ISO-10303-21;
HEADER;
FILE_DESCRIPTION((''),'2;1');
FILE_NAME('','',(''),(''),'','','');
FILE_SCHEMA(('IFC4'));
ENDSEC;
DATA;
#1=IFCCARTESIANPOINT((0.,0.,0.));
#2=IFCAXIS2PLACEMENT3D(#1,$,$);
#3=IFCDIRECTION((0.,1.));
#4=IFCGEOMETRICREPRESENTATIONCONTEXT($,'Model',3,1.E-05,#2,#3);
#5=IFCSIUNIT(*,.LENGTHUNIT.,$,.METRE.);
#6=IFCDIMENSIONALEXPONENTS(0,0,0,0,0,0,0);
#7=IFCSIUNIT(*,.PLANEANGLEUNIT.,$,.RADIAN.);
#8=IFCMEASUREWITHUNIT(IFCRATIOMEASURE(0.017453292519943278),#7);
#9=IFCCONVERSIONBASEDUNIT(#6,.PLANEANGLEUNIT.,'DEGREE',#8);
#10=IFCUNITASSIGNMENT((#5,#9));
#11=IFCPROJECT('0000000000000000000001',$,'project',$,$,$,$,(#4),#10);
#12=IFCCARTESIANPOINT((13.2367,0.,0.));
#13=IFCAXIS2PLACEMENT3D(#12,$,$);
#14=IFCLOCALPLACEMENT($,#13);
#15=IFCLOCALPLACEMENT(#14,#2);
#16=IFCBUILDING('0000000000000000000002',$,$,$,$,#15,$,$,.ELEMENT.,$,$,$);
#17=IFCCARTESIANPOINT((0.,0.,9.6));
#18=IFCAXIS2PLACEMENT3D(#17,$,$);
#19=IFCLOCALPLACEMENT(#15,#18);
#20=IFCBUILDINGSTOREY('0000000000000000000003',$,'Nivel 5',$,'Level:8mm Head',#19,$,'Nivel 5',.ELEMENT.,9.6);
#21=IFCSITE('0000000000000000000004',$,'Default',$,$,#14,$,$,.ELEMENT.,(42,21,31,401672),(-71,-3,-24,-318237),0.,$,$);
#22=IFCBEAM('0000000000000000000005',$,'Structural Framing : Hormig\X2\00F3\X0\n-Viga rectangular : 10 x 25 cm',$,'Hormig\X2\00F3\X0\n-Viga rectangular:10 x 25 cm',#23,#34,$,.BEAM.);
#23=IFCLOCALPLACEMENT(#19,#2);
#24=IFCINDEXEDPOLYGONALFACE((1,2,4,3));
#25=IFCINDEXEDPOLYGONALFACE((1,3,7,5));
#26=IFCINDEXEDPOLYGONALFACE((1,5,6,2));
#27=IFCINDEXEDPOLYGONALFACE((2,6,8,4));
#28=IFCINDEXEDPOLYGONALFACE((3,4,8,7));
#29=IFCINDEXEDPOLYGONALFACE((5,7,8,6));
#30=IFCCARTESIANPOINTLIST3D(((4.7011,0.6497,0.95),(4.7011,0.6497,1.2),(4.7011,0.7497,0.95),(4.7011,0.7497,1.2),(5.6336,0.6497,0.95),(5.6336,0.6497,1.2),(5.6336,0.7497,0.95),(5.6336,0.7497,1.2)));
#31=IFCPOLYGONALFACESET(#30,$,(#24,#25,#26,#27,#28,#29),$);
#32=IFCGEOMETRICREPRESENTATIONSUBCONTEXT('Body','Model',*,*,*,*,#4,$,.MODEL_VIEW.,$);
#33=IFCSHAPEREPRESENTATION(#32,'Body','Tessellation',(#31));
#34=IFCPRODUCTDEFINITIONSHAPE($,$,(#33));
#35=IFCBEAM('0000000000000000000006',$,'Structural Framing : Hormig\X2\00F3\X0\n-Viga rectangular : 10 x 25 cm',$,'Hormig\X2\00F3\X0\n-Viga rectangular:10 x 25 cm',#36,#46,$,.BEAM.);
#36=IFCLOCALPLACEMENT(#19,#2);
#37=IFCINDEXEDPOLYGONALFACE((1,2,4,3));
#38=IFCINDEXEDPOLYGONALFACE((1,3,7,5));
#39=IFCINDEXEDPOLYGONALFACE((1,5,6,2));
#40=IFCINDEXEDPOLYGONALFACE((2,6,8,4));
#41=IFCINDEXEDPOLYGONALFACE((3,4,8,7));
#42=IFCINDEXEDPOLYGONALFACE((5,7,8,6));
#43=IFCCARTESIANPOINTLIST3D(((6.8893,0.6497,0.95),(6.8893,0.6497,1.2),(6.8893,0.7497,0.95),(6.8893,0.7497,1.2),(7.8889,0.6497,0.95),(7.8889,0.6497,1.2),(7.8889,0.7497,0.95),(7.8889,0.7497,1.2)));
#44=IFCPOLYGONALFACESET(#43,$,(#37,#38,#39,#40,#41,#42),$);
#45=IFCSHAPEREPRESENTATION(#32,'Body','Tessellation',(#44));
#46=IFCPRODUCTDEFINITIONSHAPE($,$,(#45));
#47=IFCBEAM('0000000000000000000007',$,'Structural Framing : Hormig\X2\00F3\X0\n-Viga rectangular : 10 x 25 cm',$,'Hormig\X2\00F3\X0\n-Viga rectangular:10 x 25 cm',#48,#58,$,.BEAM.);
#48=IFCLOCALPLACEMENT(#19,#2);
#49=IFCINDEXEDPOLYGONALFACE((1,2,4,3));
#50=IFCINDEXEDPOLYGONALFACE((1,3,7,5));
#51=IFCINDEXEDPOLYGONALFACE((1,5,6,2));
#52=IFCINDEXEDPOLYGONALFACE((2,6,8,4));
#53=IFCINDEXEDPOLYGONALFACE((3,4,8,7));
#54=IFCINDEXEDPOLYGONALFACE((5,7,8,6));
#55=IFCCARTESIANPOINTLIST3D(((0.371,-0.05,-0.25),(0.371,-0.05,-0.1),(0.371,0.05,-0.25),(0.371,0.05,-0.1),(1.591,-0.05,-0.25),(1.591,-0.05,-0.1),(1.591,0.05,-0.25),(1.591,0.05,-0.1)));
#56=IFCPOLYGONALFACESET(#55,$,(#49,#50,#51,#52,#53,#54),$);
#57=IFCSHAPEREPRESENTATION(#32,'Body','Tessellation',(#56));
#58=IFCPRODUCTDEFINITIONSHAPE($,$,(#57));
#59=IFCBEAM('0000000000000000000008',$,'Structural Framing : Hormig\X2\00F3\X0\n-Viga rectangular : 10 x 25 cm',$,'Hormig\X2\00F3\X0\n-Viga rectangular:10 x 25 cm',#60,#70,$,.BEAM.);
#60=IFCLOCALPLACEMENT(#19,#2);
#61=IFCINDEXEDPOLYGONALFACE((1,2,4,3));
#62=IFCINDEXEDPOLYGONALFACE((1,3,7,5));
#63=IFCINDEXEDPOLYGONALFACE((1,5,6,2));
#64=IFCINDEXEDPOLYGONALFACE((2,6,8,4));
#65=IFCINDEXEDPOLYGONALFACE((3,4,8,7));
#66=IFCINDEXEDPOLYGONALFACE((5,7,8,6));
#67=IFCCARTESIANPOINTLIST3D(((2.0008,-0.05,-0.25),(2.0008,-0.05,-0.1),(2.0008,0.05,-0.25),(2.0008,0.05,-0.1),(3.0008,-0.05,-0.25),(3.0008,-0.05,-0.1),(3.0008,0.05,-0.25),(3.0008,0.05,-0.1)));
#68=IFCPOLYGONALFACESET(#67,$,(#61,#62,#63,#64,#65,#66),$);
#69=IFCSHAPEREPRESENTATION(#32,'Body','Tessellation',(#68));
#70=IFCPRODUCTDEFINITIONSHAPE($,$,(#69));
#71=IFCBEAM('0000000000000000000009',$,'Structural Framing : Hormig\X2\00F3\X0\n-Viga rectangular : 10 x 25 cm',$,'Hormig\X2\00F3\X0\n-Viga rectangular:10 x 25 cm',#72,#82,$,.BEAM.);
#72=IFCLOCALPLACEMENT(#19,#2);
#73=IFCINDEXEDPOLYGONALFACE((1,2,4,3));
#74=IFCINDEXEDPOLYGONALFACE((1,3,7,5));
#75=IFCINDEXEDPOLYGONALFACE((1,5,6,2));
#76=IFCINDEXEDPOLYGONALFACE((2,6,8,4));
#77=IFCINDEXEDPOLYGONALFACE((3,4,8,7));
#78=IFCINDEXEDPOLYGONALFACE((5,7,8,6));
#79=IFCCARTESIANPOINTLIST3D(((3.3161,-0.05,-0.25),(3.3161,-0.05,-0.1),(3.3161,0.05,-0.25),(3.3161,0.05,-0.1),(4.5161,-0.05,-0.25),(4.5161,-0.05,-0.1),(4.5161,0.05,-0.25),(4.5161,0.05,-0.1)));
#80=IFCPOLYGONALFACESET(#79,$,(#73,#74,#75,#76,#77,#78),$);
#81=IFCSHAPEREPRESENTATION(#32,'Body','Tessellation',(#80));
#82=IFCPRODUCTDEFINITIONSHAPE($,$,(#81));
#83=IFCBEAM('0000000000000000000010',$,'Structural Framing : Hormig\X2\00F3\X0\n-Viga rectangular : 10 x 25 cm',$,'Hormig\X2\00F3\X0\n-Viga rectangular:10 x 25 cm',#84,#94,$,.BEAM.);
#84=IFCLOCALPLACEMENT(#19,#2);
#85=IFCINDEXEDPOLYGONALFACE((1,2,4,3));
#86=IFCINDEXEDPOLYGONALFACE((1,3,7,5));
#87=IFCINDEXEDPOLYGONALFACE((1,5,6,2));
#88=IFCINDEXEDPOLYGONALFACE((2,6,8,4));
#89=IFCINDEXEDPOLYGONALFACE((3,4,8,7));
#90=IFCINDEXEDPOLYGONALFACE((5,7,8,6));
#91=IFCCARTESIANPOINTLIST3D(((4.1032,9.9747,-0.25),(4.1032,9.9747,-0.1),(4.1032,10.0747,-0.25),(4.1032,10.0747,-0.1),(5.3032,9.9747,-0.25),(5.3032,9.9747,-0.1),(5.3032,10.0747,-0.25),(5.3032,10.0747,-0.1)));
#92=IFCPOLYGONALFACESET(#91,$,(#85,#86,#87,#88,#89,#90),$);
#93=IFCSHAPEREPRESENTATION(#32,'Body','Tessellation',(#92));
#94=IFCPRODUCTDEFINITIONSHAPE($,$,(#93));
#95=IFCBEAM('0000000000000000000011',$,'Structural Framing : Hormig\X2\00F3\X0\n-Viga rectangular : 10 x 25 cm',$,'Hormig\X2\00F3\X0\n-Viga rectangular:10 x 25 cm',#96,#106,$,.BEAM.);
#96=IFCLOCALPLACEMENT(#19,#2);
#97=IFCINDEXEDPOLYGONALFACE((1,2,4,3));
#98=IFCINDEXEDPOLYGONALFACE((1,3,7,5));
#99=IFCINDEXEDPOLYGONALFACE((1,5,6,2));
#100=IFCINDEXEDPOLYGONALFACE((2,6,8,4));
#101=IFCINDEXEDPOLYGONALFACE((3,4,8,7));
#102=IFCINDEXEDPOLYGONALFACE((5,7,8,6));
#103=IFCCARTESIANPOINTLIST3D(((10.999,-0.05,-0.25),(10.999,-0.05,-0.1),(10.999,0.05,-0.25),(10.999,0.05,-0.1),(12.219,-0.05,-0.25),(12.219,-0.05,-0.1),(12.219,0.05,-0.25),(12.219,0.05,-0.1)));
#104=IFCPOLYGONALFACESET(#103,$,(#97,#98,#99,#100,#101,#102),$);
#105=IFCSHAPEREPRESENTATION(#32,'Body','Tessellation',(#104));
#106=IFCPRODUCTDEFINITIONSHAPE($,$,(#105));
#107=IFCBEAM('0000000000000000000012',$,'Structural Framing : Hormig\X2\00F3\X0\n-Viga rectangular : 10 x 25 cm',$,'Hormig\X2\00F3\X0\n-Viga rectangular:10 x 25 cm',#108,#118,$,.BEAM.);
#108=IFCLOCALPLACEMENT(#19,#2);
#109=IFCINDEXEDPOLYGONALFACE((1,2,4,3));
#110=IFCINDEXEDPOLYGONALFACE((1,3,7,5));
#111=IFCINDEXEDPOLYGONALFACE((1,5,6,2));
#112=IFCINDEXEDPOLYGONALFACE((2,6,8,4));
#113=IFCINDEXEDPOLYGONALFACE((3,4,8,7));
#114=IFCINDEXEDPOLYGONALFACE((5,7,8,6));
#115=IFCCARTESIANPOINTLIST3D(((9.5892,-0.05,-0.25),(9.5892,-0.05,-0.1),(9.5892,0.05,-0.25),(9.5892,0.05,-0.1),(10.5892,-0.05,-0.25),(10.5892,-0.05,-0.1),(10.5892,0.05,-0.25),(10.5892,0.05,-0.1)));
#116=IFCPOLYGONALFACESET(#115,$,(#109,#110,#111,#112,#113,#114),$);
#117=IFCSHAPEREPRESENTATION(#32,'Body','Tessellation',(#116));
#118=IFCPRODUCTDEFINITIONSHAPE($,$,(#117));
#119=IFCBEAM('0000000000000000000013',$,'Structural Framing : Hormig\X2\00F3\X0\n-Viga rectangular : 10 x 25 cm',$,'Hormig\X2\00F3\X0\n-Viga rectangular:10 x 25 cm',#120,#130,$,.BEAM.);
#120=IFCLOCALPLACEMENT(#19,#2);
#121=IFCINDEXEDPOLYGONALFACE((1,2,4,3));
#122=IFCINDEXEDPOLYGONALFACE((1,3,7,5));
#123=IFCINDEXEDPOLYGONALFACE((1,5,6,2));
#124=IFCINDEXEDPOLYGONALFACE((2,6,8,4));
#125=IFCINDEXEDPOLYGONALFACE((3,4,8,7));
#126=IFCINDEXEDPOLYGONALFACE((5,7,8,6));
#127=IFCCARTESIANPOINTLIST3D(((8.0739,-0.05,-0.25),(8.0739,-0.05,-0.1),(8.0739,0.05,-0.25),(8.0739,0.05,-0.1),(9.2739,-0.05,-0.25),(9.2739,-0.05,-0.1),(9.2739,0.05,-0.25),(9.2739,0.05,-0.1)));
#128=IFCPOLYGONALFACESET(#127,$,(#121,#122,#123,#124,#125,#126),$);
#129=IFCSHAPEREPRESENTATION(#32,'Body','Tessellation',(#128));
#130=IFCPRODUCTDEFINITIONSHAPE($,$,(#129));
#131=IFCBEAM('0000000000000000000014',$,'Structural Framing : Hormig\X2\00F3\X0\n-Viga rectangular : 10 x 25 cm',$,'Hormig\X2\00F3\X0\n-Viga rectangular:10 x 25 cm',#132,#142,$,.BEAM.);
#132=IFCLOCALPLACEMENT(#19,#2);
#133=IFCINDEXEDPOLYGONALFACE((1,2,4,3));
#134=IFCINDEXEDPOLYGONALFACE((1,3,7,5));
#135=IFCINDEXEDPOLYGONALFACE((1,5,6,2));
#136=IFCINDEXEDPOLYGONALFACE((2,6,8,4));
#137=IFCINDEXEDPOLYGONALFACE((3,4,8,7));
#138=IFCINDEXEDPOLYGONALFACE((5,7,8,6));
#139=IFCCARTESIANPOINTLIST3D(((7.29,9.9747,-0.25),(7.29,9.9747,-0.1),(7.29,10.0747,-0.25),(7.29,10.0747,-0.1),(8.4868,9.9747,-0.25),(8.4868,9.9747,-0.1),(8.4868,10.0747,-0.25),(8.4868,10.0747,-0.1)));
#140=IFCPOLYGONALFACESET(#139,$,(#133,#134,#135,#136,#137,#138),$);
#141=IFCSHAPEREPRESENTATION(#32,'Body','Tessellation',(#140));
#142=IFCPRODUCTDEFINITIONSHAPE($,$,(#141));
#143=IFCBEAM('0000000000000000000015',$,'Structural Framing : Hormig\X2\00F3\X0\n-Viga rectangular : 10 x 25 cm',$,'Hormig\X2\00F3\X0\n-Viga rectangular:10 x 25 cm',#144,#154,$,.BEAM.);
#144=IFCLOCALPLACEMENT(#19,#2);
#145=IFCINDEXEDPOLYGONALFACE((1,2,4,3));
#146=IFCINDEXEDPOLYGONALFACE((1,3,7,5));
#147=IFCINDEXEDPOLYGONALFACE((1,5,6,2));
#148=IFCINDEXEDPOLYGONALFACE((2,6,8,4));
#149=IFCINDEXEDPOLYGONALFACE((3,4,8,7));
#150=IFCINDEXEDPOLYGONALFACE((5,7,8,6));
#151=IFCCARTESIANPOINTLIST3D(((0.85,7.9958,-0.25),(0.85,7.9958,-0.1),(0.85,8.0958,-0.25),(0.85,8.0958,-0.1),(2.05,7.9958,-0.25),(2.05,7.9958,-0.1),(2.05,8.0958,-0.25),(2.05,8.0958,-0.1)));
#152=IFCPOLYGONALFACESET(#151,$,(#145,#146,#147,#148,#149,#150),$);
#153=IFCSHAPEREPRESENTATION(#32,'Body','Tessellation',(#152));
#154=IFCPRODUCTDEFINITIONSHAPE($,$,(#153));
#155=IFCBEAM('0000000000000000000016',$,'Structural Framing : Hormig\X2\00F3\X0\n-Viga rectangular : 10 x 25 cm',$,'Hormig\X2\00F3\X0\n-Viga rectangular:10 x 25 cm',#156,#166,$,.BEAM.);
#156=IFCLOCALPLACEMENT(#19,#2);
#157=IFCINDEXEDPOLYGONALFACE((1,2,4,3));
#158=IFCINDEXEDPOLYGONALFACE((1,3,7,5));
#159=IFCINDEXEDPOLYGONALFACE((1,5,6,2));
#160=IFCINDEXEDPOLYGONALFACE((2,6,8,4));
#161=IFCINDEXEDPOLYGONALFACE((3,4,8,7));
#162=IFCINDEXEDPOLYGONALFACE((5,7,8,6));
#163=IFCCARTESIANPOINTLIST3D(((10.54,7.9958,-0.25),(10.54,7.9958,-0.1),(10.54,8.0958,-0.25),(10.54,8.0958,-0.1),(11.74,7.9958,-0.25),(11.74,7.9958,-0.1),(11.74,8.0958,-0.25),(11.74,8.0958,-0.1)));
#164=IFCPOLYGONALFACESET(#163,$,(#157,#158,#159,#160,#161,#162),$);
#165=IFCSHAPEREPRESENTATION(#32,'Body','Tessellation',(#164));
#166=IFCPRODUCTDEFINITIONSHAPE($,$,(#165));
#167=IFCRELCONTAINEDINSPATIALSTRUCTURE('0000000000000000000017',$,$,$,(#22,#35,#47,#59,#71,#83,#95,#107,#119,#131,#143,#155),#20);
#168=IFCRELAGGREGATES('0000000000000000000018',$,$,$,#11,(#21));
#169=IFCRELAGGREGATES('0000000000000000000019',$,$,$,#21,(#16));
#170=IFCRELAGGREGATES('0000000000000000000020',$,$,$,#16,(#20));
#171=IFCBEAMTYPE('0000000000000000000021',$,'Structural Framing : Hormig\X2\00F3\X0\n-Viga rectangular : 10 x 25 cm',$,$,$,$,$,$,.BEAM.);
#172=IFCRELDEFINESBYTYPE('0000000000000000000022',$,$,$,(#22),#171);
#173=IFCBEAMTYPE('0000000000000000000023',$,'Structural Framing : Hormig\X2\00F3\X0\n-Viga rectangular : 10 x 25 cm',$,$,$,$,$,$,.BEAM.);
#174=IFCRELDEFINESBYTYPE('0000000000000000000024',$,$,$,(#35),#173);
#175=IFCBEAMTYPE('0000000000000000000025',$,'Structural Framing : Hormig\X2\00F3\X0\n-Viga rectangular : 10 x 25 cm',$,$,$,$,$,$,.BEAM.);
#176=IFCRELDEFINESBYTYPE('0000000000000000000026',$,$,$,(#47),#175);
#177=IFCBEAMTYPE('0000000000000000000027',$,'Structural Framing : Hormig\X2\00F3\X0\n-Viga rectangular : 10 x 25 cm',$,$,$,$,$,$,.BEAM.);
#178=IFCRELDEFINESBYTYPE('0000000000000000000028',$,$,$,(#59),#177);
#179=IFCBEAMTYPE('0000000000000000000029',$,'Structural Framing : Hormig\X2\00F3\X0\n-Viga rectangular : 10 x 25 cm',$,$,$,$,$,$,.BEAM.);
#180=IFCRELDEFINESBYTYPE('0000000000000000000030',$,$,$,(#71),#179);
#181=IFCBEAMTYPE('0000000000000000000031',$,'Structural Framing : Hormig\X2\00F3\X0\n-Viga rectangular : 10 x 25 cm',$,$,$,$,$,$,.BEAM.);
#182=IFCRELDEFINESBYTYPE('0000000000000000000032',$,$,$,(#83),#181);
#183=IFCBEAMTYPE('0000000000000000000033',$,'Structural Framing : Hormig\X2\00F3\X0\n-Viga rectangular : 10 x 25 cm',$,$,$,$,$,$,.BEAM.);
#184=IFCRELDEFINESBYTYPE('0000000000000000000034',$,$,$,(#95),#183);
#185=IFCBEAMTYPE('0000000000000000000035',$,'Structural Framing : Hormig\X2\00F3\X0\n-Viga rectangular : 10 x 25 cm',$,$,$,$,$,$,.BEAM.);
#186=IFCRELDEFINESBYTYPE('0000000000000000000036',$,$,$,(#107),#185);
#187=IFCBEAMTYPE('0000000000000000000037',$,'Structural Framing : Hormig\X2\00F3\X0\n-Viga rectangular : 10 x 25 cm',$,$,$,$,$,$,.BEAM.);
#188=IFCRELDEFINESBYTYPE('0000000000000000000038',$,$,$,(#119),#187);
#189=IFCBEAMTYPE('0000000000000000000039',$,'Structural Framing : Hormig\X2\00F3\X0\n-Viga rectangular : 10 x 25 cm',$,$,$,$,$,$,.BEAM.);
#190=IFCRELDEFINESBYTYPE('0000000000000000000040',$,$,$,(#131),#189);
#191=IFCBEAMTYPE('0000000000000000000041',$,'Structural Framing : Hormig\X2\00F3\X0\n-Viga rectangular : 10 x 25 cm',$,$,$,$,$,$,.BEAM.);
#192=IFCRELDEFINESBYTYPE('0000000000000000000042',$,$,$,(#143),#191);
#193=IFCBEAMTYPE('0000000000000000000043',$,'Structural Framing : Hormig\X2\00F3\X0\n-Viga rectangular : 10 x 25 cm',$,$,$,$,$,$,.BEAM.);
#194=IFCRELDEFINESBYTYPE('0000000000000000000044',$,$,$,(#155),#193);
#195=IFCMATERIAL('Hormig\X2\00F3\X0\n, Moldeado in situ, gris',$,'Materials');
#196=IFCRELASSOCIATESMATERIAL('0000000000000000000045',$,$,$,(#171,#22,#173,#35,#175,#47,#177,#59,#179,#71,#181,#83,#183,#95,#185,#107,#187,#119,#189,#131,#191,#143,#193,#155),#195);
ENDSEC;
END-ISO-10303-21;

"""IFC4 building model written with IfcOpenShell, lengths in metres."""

from ifc_helpers import new_model, entity, si_unit, converted_unit, direction, frame, origin, place, context, subcontext, project, spatial, indexed_curve, outline, extrude, source, transform, mapped, material, type_object, type_shapes, element, save


model = new_model("IFC4")

# Units and contexts
model_context = context("Model", 3, precision=1e-05, world=origin(), true_north=direction((0.0, 1.0)))
body_context = subcontext(model_context, "Body", "Model", "MODEL_VIEW")
ifc_project = project(units=[si_unit("LENGTHUNIT", "METRE"), converted_unit("PLANEANGLEUNIT", "DEGREE", entity("IfcRatioMeasure", 0.017453292519943278), si_unit("PLANEANGLEUNIT", "RADIAN"), dimensions=[0, 0, 0, 0, 0, 0, 0])], contexts=[model_context])

# Site, building, storey
site_placement = place(None, frame((13.2367, 0.0, 0.0)))
site = spatial("IfcSite", under=ifc_project, at=site_placement, Name="Default", CompositionType="ELEMENT", RefLatitude=(42, 21, 31, 401672), RefLongitude=(-71, -3, -24, -318237), RefElevation=0.0)
building_placement = place(site_placement, origin())
building = spatial("IfcBuilding", under=site, at=building_placement, CompositionType="ELEMENT")
storey_placement = place(building_placement, frame((0.0, 0.0, 9.6)))
storey = spatial("IfcBuildingStorey", under=building, at=storey_placement, Name="Nivel 5", ObjectType="Level:8mm Head", LongName="Nivel 5", CompositionType="ELEMENT", Elevation=9.6)

# Beams
ifc_material_1 = material(Name="Hormigón, Moldeado in situ, gris", Category="Materials")
beam_type_1 = type_object("IfcBeamType", Name="Structural Framing : Hormigón-Viga rectangular : 10 x 25 cm", PredefinedType="BEAM", material=ifc_material_1)
shared_shape_1 = source(origin(), body_context, "Body", "SweptSolid", [
    extrude(outline(indexed_curve([(-0.125, -0.05), (0.125, -0.05), (0.125, 0.05), (-0.125, 0.05), (-0.125, -0.05)], self_intersect=False)), frame((5.6336, 0.6997, 10.675), z_axis=(-1.0, 0.0, 0.0), x_axis=(0.0, 0.0, -1.0)), (0.0, 0.0, 1.0), 0.9325),
])
type_shapes(beam_type_1, [shared_shape_1])
beam_1_placement = place(storey_placement, frame((0.0, 0.0, -9.6)))
element("IfcBeam", 1, at=beam_1_placement, inside=storey, type_object=beam_type_1, material=ifc_material_1, Name="Structural Framing : Hormigón-Viga rectangular : 10 x 25 cm", ObjectType="Hormigón-Viga rectangular:10 x 25 cm", PredefinedType="BEAM", context=body_context, shape_type="MappedRepresentation", body=[
    mapped(shared_shape_1, transform((0.0, 0.0, 0.0), scale=1.0)),
])
beam_type_2 = type_object("IfcBeamType", Name="Structural Framing : Hormigón-Viga rectangular : 10 x 25 cm", PredefinedType="BEAM", material=ifc_material_1)
shared_shape_2 = source(origin(), body_context, "Body", "SweptSolid", [
    extrude(outline(indexed_curve([(-0.125, -0.05), (0.125, -0.05), (0.125, 0.05), (-0.125, 0.05), (-0.125, -0.05)], self_intersect=False)), frame((7.8889, 0.6997, 10.675), z_axis=(-1.0, 0.0, 0.0), x_axis=(0.0, 0.0, -1.0)), (0.0, 0.0, 1.0), 0.9996),
])
type_shapes(beam_type_2, [shared_shape_2])
beam_2_placement = place(storey_placement, frame((0.0, 0.0, -9.6)))
element("IfcBeam", 2, at=beam_2_placement, inside=storey, type_object=beam_type_2, material=ifc_material_1, Name="Structural Framing : Hormigón-Viga rectangular : 10 x 25 cm", ObjectType="Hormigón-Viga rectangular:10 x 25 cm", PredefinedType="BEAM", context=body_context, shape_type="MappedRepresentation", body=[
    mapped(shared_shape_2, transform((0.0, 0.0, 0.0), scale=1.0)),
])
beam_type_3 = type_object("IfcBeamType", Name="Structural Framing : Hormigón-Viga rectangular : 10 x 25 cm", PredefinedType="BEAM", material=ifc_material_1)
shared_shape_3 = source(origin(), body_context, "Body", "SweptSolid", [
    extrude(outline(indexed_curve([(-0.075, -0.05), (0.075, -0.05), (0.075, 0.05), (-0.075, 0.05), (-0.075, -0.05)], self_intersect=False)), frame((0.371, 0.0, 9.425), z_axis=(1.0, 0.0, 0.0), x_axis=(0.0, 0.0, -1.0)), (0.0, 0.0, 1.0), 1.22),
])
type_shapes(beam_type_3, [shared_shape_3])
beam_3_placement = place(storey_placement, frame((0.0, 0.0, -9.6)))
element("IfcBeam", 3, at=beam_3_placement, inside=storey, type_object=beam_type_3, material=ifc_material_1, Name="Structural Framing : Hormigón-Viga rectangular : 10 x 25 cm", ObjectType="Hormigón-Viga rectangular:10 x 25 cm", PredefinedType="BEAM", context=body_context, shape_type="MappedRepresentation", body=[
    mapped(shared_shape_3, transform((0.0, 0.0, 0.0), scale=1.0)),
])
beam_type_4 = type_object("IfcBeamType", Name="Structural Framing : Hormigón-Viga rectangular : 10 x 25 cm", PredefinedType="BEAM", material=ifc_material_1)
shared_shape_4 = source(origin(), body_context, "Body", "SweptSolid", [
    extrude(outline(indexed_curve([(-0.075, -0.05), (0.075, -0.05), (0.075, 0.05), (-0.075, 0.05), (-0.075, -0.05)], self_intersect=False)), frame((2.0008, 0.0, 9.425), z_axis=(1.0, 0.0, 0.0), x_axis=(0.0, 0.0, -1.0)), (0.0, 0.0, 1.0), 1.0),
])
type_shapes(beam_type_4, [shared_shape_4])
beam_4_placement = place(storey_placement, frame((0.0, 0.0, -9.6)))
element("IfcBeam", 4, at=beam_4_placement, inside=storey, type_object=beam_type_4, material=ifc_material_1, Name="Structural Framing : Hormigón-Viga rectangular : 10 x 25 cm", ObjectType="Hormigón-Viga rectangular:10 x 25 cm", PredefinedType="BEAM", context=body_context, shape_type="MappedRepresentation", body=[
    mapped(shared_shape_4, transform((0.0, 0.0, 0.0), scale=1.0)),
])
beam_type_5 = type_object("IfcBeamType", Name="Structural Framing : Hormigón-Viga rectangular : 10 x 25 cm", PredefinedType="BEAM", material=ifc_material_1)
shared_shape_5 = source(origin(), body_context, "Body", "SweptSolid", [
    extrude(outline(indexed_curve([(-0.075, -0.05), (0.075, -0.05), (0.075, 0.05), (-0.075, 0.05), (-0.075, -0.05)], self_intersect=False)), frame((3.3161, 0.0, 9.425), z_axis=(1.0, 0.0, 0.0), x_axis=(0.0, 0.0, -1.0)), (0.0, 0.0, 1.0), 1.2),
])
type_shapes(beam_type_5, [shared_shape_5])
beam_5_placement = place(storey_placement, frame((0.0, 0.0, -9.6)))
element("IfcBeam", 5, at=beam_5_placement, inside=storey, type_object=beam_type_5, material=ifc_material_1, Name="Structural Framing : Hormigón-Viga rectangular : 10 x 25 cm", ObjectType="Hormigón-Viga rectangular:10 x 25 cm", PredefinedType="BEAM", context=body_context, shape_type="MappedRepresentation", body=[
    mapped(shared_shape_5, transform((0.0, 0.0, 0.0), scale=1.0)),
])
beam_type_6 = type_object("IfcBeamType", Name="Structural Framing : Hormigón-Viga rectangular : 10 x 25 cm", PredefinedType="BEAM", material=ifc_material_1)
shared_shape_6 = source(origin(), body_context, "Body", "SweptSolid", [
    extrude(outline(indexed_curve([(-0.075, -0.05), (0.075, -0.05), (0.075, 0.05), (-0.075, 0.05), (-0.075, -0.05)], self_intersect=False)), frame((5.3032, 10.0247, 9.425), z_axis=(-1.0, 0.0, 0.0), x_axis=(0.0, 0.0, -1.0)), (0.0, 0.0, 1.0), 1.2),
])
type_shapes(beam_type_6, [shared_shape_6])
beam_6_placement = place(storey_placement, frame((0.0, 0.0, -9.6)))
element("IfcBeam", 6, at=beam_6_placement, inside=storey, type_object=beam_type_6, material=ifc_material_1, Name="Structural Framing : Hormigón-Viga rectangular : 10 x 25 cm", ObjectType="Hormigón-Viga rectangular:10 x 25 cm", PredefinedType="BEAM", context=body_context, shape_type="MappedRepresentation", body=[
    mapped(shared_shape_6, transform((0.0, 0.0, 0.0), scale=1.0)),
])
beam_type_7 = type_object("IfcBeamType", Name="Structural Framing : Hormigón-Viga rectangular : 10 x 25 cm", PredefinedType="BEAM", material=ifc_material_1)
shared_shape_7 = source(origin(), body_context, "Body", "SweptSolid", [
    extrude(outline(indexed_curve([(-0.075, -0.05), (0.075, -0.05), (0.075, 0.05), (-0.075, 0.05), (-0.075, -0.05)], self_intersect=False)), frame((12.219, 0.0, 9.425), z_axis=(-1.0, 0.0, 0.0), x_axis=(0.0, 0.0, -1.0)), (0.0, 0.0, 1.0), 1.22),
])
type_shapes(beam_type_7, [shared_shape_7])
beam_7_placement = place(storey_placement, frame((0.0, 0.0, -9.6)))
element("IfcBeam", 7, at=beam_7_placement, inside=storey, type_object=beam_type_7, material=ifc_material_1, Name="Structural Framing : Hormigón-Viga rectangular : 10 x 25 cm", ObjectType="Hormigón-Viga rectangular:10 x 25 cm", PredefinedType="BEAM", context=body_context, shape_type="MappedRepresentation", body=[
    mapped(shared_shape_7, transform((0.0, 0.0, 0.0), scale=1.0)),
])
beam_type_8 = type_object("IfcBeamType", Name="Structural Framing : Hormigón-Viga rectangular : 10 x 25 cm", PredefinedType="BEAM", material=ifc_material_1)
shared_shape_8 = source(origin(), body_context, "Body", "SweptSolid", [
    extrude(outline(indexed_curve([(-0.075, -0.05), (0.075, -0.05), (0.075, 0.05), (-0.075, 0.05), (-0.075, -0.05)], self_intersect=False)), frame((10.5892, 0.0, 9.425), z_axis=(-1.0, 0.0, 0.0), x_axis=(0.0, 0.0, -1.0)), (0.0, 0.0, 1.0), 1.0),
])
type_shapes(beam_type_8, [shared_shape_8])
beam_8_placement = place(storey_placement, frame((0.0, 0.0, -9.6)))
element("IfcBeam", 8, at=beam_8_placement, inside=storey, type_object=beam_type_8, material=ifc_material_1, Name="Structural Framing : Hormigón-Viga rectangular : 10 x 25 cm", ObjectType="Hormigón-Viga rectangular:10 x 25 cm", PredefinedType="BEAM", context=body_context, shape_type="MappedRepresentation", body=[
    mapped(shared_shape_8, transform((0.0, 0.0, 0.0), scale=1.0)),
])
beam_type_9 = type_object("IfcBeamType", Name="Structural Framing : Hormigón-Viga rectangular : 10 x 25 cm", PredefinedType="BEAM", material=ifc_material_1)
shared_shape_9 = source(origin(), body_context, "Body", "SweptSolid", [
    extrude(outline(indexed_curve([(-0.075, -0.05), (0.075, -0.05), (0.075, 0.05), (-0.075, 0.05), (-0.075, -0.05)], self_intersect=False)), frame((9.2739, 0.0, 9.425), z_axis=(-1.0, 0.0, 0.0), x_axis=(0.0, 0.0, -1.0)), (0.0, 0.0, 1.0), 1.2),
])
type_shapes(beam_type_9, [shared_shape_9])
beam_9_placement = place(storey_placement, frame((0.0, 0.0, -9.6)))
element("IfcBeam", 9, at=beam_9_placement, inside=storey, type_object=beam_type_9, material=ifc_material_1, Name="Structural Framing : Hormigón-Viga rectangular : 10 x 25 cm", ObjectType="Hormigón-Viga rectangular:10 x 25 cm", PredefinedType="BEAM", context=body_context, shape_type="MappedRepresentation", body=[
    mapped(shared_shape_9, transform((0.0, 0.0, 0.0), scale=1.0)),
])
beam_type_10 = type_object("IfcBeamType", Name="Structural Framing : Hormigón-Viga rectangular : 10 x 25 cm", PredefinedType="BEAM", material=ifc_material_1)
shared_shape_10 = source(origin(), body_context, "Body", "SweptSolid", [
    extrude(outline(indexed_curve([(-0.075, -0.05), (0.075, -0.05), (0.075, 0.05), (-0.075, 0.05), (-0.075, -0.05)], self_intersect=False)), frame((7.29, 10.0247, 9.425), z_axis=(1.0, 0.0, 0.0), x_axis=(0.0, 0.0, -1.0)), (0.0, 0.0, 1.0), 1.1968),
])
type_shapes(beam_type_10, [shared_shape_10])
beam_10_placement = place(storey_placement, frame((0.0, 0.0, -9.6)))
element("IfcBeam", 10, at=beam_10_placement, inside=storey, type_object=beam_type_10, material=ifc_material_1, Name="Structural Framing : Hormigón-Viga rectangular : 10 x 25 cm", ObjectType="Hormigón-Viga rectangular:10 x 25 cm", PredefinedType="BEAM", context=body_context, shape_type="MappedRepresentation", body=[
    mapped(shared_shape_10, transform((0.0, 0.0, 0.0), scale=1.0)),
])
beam_type_11 = type_object("IfcBeamType", Name="Structural Framing : Hormigón-Viga rectangular : 10 x 25 cm", PredefinedType="BEAM", material=ifc_material_1)
shared_shape_11 = source(origin(), body_context, "Body", "SweptSolid", [
    extrude(outline(indexed_curve([(-0.075, -0.05), (0.075, -0.05), (0.075, 0.05), (-0.075, 0.05), (-0.075, -0.05)], self_intersect=False)), frame((2.05, 8.0458, 9.425), z_axis=(-1.0, 0.0, 0.0), x_axis=(0.0, 0.0, -1.0)), (0.0, 0.0, 1.0), 1.2),
])
type_shapes(beam_type_11, [shared_shape_11])
beam_11_placement = place(storey_placement, frame((0.0, 0.0, -9.6)))
element("IfcBeam", 11, at=beam_11_placement, inside=storey, type_object=beam_type_11, material=ifc_material_1, Name="Structural Framing : Hormigón-Viga rectangular : 10 x 25 cm", ObjectType="Hormigón-Viga rectangular:10 x 25 cm", PredefinedType="BEAM", context=body_context, shape_type="MappedRepresentation", body=[
    mapped(shared_shape_11, transform((0.0, 0.0, 0.0), scale=1.0)),
])
beam_type_12 = type_object("IfcBeamType", Name="Structural Framing : Hormigón-Viga rectangular : 10 x 25 cm", PredefinedType="BEAM", material=ifc_material_1)
shared_shape_12 = source(origin(), body_context, "Body", "SweptSolid", [
    extrude(outline(indexed_curve([(-0.075, -0.05), (0.075, -0.05), (0.075, 0.05), (-0.075, 0.05), (-0.075, -0.05)], self_intersect=False)), frame((10.54, 8.0458, 9.425), z_axis=(1.0, 0.0, 0.0), x_axis=(0.0, 0.0, -1.0)), (0.0, 0.0, 1.0), 1.2),
])
type_shapes(beam_type_12, [shared_shape_12])
beam_12_placement = place(storey_placement, frame((0.0, 0.0, -9.6)))
element("IfcBeam", 12, at=beam_12_placement, inside=storey, type_object=beam_type_12, material=ifc_material_1, Name="Structural Framing : Hormigón-Viga rectangular : 10 x 25 cm", ObjectType="Hormigón-Viga rectangular:10 x 25 cm", PredefinedType="BEAM", context=body_context, shape_type="MappedRepresentation", body=[
    mapped(shared_shape_12, transform((0.0, 0.0, 0.0), scale=1.0)),
])

save(model, "model.ifc")
